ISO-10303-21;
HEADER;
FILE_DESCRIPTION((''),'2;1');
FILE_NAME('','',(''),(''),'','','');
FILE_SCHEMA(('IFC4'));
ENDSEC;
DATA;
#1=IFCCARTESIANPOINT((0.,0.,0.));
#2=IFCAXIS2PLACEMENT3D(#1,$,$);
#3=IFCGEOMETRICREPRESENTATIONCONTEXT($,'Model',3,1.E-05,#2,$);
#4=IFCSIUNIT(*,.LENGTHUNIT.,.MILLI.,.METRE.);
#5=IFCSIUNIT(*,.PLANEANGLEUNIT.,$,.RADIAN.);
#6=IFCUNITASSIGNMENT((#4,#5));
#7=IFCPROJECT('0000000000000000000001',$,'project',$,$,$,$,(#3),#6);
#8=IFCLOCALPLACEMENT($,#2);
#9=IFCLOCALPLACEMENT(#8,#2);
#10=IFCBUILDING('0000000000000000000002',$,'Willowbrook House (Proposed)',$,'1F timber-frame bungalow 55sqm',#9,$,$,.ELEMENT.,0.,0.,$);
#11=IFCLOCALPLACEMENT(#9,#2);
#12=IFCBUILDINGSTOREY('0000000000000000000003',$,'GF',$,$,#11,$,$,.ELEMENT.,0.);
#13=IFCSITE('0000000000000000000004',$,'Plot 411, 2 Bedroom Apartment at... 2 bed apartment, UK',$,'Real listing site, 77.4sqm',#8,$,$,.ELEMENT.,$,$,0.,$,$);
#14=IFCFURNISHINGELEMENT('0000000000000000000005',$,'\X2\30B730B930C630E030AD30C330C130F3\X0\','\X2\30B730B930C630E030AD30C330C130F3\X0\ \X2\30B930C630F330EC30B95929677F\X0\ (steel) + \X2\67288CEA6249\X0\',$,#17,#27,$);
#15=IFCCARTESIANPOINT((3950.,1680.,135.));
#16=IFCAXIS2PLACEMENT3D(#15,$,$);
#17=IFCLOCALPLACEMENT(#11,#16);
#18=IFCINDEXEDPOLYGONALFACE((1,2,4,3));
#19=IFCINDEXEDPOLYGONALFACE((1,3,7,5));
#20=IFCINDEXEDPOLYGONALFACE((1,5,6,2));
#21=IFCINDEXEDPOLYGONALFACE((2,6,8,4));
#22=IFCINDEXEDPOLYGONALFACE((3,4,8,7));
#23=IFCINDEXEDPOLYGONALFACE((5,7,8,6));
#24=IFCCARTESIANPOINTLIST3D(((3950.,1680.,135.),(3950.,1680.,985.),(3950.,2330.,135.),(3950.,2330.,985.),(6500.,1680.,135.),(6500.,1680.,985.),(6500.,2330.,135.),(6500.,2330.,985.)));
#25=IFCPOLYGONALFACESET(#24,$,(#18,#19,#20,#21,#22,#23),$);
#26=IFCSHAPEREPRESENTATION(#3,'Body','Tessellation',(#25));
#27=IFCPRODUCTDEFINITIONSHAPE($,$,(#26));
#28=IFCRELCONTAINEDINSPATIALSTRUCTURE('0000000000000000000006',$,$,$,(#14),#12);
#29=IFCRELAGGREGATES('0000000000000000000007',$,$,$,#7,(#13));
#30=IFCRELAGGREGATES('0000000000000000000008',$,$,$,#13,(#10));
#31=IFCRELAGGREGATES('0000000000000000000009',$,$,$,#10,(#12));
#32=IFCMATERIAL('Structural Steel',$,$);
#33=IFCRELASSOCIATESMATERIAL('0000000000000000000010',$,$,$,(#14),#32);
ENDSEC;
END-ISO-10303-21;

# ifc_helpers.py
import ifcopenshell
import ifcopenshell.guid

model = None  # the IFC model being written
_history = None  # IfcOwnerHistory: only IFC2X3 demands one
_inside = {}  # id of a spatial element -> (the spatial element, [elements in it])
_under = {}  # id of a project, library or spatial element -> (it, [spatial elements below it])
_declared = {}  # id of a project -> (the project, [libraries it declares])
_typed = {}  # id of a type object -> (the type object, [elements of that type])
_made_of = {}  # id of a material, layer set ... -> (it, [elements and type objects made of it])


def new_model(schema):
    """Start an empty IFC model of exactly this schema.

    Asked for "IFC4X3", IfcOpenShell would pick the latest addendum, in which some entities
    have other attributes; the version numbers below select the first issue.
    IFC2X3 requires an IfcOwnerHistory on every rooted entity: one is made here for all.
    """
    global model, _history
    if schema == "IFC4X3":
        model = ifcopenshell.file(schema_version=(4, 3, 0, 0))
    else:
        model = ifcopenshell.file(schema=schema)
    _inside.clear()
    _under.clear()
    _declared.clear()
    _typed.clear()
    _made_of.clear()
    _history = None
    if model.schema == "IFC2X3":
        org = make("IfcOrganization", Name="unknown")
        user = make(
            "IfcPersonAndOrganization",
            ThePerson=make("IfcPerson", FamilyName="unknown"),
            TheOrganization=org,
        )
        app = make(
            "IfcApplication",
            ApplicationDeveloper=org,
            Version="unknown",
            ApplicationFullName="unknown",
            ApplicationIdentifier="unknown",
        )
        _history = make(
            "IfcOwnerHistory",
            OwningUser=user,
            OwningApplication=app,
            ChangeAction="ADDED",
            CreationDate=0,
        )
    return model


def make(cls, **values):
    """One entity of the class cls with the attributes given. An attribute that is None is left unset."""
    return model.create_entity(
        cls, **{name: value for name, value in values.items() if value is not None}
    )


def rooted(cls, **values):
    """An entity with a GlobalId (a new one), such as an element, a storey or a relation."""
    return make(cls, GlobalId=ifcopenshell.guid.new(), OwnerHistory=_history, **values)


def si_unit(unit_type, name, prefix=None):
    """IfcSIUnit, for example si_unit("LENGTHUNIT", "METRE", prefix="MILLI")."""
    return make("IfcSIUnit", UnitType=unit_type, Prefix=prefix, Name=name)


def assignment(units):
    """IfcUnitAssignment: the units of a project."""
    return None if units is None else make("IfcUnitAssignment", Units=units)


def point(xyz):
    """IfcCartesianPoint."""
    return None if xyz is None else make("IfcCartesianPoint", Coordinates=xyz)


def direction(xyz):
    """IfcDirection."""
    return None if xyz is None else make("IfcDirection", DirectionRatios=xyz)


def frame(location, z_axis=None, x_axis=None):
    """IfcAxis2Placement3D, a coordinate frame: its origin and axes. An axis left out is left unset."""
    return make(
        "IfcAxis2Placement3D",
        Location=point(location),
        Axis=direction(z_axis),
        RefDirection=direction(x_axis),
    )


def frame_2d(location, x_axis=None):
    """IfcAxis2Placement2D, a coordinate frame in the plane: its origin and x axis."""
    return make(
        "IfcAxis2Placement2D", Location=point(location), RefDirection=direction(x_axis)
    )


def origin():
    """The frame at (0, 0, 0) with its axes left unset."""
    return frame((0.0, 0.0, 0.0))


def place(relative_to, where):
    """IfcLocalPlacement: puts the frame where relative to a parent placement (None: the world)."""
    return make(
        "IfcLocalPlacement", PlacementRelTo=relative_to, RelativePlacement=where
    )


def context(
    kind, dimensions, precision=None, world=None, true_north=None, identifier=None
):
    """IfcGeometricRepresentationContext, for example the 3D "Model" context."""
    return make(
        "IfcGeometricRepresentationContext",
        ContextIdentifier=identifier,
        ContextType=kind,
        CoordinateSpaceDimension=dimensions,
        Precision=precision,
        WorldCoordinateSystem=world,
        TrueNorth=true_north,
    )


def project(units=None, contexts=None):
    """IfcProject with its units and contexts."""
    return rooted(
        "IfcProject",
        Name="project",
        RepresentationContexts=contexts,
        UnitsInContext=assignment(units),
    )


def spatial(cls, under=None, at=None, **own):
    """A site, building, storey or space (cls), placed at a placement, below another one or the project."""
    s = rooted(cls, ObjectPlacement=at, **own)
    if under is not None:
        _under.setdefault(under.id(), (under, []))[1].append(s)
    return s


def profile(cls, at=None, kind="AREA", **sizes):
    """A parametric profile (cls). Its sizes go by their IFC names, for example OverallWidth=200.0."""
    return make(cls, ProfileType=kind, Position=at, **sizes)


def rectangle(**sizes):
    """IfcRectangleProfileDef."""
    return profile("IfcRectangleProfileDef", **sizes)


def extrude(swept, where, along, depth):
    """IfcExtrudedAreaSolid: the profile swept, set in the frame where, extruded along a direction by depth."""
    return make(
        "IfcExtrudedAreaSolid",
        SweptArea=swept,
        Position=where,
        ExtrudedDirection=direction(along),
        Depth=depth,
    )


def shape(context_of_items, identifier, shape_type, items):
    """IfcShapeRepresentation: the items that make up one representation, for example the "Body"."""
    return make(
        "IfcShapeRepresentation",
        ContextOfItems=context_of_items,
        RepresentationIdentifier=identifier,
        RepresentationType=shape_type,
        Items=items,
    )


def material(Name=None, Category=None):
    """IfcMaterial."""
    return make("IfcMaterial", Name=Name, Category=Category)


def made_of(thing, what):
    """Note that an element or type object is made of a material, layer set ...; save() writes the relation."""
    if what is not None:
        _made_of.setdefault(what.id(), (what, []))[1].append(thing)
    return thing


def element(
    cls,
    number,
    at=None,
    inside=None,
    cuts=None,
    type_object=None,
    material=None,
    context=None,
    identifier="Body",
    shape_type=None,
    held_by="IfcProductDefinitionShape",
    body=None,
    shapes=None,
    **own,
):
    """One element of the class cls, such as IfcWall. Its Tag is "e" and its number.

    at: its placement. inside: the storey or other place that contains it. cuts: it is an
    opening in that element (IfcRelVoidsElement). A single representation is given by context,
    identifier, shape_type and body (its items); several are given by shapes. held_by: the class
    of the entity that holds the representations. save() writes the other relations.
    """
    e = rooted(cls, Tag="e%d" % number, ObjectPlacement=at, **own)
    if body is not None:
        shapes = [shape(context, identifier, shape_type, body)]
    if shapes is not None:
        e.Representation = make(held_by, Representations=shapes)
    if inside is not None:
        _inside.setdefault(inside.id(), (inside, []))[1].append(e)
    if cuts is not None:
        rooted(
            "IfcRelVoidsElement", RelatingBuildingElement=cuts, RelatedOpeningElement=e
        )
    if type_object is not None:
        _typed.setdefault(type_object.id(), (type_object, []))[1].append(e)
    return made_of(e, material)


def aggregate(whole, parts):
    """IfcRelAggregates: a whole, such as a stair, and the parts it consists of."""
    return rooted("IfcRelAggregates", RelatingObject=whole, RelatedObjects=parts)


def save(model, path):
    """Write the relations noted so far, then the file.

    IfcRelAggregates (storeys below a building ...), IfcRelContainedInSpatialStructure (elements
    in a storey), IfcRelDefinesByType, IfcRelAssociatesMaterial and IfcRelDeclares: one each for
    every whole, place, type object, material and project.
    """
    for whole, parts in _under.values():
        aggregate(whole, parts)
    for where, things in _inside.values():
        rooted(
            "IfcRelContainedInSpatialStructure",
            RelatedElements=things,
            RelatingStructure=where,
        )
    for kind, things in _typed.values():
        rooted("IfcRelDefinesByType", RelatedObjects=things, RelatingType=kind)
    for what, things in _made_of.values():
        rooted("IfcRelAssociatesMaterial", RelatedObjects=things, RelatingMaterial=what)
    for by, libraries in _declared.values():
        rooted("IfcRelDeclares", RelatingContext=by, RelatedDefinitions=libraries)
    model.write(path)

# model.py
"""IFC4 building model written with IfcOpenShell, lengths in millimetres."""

from ifc_helpers import new_model, si_unit, frame, frame_2d, origin, place, context, project, spatial, rectangle, extrude, material, element, save


model = new_model("IFC4")

# Units and contexts
model_context = context("Model", 3, precision=1e-05, world=origin())
ifc_project = project(units=[si_unit("LENGTHUNIT", "METRE", prefix="MILLI"), si_unit("PLANEANGLEUNIT", "RADIAN")], contexts=[model_context])

# Site, building, storey
site_placement = place(None, origin())
site = spatial("IfcSite", under=ifc_project, at=site_placement, Name="Plot 411, 2 Bedroom Apartment at... 2 bed apartment, UK", ObjectType="Real listing site, 77.4sqm", CompositionType="ELEMENT", RefElevation=0.0)
building_placement = place(site_placement, origin())
building = spatial("IfcBuilding", under=site, at=building_placement, Name="Willowbrook House (Proposed)", ObjectType="1F timber-frame bungalow 55sqm", CompositionType="ELEMENT", ElevationOfRefHeight=0.0, ElevationOfTerrain=0.0)
storey_placement = place(building_placement, origin())
storey = spatial("IfcBuildingStorey", under=building, at=storey_placement, Name="GF", CompositionType="ELEMENT", Elevation=0.0)

# Furnishing element
ifc_material_1 = material(Name="Structural Steel")
furnishing_1_placement = place(storey_placement, frame((3950.0, 1680.0, 135.0)))
element("IfcFurnishingElement", 1, at=furnishing_1_placement, inside=storey, material=ifc_material_1, Name="システムキッチン", Description="システムキッチン ステンレス天板 (steel) + 木質扉", context=model_context, shape_type="SweptSolid", body=[
    extrude(rectangle(XDim=2550.0, YDim=650.0, at=frame_2d((1275.0, 325.0))), frame((3950.0, 1680.0, 135.0)), (0.0, 0.0, 1.0), 850.0),
])

save(model, "model.ifc")
